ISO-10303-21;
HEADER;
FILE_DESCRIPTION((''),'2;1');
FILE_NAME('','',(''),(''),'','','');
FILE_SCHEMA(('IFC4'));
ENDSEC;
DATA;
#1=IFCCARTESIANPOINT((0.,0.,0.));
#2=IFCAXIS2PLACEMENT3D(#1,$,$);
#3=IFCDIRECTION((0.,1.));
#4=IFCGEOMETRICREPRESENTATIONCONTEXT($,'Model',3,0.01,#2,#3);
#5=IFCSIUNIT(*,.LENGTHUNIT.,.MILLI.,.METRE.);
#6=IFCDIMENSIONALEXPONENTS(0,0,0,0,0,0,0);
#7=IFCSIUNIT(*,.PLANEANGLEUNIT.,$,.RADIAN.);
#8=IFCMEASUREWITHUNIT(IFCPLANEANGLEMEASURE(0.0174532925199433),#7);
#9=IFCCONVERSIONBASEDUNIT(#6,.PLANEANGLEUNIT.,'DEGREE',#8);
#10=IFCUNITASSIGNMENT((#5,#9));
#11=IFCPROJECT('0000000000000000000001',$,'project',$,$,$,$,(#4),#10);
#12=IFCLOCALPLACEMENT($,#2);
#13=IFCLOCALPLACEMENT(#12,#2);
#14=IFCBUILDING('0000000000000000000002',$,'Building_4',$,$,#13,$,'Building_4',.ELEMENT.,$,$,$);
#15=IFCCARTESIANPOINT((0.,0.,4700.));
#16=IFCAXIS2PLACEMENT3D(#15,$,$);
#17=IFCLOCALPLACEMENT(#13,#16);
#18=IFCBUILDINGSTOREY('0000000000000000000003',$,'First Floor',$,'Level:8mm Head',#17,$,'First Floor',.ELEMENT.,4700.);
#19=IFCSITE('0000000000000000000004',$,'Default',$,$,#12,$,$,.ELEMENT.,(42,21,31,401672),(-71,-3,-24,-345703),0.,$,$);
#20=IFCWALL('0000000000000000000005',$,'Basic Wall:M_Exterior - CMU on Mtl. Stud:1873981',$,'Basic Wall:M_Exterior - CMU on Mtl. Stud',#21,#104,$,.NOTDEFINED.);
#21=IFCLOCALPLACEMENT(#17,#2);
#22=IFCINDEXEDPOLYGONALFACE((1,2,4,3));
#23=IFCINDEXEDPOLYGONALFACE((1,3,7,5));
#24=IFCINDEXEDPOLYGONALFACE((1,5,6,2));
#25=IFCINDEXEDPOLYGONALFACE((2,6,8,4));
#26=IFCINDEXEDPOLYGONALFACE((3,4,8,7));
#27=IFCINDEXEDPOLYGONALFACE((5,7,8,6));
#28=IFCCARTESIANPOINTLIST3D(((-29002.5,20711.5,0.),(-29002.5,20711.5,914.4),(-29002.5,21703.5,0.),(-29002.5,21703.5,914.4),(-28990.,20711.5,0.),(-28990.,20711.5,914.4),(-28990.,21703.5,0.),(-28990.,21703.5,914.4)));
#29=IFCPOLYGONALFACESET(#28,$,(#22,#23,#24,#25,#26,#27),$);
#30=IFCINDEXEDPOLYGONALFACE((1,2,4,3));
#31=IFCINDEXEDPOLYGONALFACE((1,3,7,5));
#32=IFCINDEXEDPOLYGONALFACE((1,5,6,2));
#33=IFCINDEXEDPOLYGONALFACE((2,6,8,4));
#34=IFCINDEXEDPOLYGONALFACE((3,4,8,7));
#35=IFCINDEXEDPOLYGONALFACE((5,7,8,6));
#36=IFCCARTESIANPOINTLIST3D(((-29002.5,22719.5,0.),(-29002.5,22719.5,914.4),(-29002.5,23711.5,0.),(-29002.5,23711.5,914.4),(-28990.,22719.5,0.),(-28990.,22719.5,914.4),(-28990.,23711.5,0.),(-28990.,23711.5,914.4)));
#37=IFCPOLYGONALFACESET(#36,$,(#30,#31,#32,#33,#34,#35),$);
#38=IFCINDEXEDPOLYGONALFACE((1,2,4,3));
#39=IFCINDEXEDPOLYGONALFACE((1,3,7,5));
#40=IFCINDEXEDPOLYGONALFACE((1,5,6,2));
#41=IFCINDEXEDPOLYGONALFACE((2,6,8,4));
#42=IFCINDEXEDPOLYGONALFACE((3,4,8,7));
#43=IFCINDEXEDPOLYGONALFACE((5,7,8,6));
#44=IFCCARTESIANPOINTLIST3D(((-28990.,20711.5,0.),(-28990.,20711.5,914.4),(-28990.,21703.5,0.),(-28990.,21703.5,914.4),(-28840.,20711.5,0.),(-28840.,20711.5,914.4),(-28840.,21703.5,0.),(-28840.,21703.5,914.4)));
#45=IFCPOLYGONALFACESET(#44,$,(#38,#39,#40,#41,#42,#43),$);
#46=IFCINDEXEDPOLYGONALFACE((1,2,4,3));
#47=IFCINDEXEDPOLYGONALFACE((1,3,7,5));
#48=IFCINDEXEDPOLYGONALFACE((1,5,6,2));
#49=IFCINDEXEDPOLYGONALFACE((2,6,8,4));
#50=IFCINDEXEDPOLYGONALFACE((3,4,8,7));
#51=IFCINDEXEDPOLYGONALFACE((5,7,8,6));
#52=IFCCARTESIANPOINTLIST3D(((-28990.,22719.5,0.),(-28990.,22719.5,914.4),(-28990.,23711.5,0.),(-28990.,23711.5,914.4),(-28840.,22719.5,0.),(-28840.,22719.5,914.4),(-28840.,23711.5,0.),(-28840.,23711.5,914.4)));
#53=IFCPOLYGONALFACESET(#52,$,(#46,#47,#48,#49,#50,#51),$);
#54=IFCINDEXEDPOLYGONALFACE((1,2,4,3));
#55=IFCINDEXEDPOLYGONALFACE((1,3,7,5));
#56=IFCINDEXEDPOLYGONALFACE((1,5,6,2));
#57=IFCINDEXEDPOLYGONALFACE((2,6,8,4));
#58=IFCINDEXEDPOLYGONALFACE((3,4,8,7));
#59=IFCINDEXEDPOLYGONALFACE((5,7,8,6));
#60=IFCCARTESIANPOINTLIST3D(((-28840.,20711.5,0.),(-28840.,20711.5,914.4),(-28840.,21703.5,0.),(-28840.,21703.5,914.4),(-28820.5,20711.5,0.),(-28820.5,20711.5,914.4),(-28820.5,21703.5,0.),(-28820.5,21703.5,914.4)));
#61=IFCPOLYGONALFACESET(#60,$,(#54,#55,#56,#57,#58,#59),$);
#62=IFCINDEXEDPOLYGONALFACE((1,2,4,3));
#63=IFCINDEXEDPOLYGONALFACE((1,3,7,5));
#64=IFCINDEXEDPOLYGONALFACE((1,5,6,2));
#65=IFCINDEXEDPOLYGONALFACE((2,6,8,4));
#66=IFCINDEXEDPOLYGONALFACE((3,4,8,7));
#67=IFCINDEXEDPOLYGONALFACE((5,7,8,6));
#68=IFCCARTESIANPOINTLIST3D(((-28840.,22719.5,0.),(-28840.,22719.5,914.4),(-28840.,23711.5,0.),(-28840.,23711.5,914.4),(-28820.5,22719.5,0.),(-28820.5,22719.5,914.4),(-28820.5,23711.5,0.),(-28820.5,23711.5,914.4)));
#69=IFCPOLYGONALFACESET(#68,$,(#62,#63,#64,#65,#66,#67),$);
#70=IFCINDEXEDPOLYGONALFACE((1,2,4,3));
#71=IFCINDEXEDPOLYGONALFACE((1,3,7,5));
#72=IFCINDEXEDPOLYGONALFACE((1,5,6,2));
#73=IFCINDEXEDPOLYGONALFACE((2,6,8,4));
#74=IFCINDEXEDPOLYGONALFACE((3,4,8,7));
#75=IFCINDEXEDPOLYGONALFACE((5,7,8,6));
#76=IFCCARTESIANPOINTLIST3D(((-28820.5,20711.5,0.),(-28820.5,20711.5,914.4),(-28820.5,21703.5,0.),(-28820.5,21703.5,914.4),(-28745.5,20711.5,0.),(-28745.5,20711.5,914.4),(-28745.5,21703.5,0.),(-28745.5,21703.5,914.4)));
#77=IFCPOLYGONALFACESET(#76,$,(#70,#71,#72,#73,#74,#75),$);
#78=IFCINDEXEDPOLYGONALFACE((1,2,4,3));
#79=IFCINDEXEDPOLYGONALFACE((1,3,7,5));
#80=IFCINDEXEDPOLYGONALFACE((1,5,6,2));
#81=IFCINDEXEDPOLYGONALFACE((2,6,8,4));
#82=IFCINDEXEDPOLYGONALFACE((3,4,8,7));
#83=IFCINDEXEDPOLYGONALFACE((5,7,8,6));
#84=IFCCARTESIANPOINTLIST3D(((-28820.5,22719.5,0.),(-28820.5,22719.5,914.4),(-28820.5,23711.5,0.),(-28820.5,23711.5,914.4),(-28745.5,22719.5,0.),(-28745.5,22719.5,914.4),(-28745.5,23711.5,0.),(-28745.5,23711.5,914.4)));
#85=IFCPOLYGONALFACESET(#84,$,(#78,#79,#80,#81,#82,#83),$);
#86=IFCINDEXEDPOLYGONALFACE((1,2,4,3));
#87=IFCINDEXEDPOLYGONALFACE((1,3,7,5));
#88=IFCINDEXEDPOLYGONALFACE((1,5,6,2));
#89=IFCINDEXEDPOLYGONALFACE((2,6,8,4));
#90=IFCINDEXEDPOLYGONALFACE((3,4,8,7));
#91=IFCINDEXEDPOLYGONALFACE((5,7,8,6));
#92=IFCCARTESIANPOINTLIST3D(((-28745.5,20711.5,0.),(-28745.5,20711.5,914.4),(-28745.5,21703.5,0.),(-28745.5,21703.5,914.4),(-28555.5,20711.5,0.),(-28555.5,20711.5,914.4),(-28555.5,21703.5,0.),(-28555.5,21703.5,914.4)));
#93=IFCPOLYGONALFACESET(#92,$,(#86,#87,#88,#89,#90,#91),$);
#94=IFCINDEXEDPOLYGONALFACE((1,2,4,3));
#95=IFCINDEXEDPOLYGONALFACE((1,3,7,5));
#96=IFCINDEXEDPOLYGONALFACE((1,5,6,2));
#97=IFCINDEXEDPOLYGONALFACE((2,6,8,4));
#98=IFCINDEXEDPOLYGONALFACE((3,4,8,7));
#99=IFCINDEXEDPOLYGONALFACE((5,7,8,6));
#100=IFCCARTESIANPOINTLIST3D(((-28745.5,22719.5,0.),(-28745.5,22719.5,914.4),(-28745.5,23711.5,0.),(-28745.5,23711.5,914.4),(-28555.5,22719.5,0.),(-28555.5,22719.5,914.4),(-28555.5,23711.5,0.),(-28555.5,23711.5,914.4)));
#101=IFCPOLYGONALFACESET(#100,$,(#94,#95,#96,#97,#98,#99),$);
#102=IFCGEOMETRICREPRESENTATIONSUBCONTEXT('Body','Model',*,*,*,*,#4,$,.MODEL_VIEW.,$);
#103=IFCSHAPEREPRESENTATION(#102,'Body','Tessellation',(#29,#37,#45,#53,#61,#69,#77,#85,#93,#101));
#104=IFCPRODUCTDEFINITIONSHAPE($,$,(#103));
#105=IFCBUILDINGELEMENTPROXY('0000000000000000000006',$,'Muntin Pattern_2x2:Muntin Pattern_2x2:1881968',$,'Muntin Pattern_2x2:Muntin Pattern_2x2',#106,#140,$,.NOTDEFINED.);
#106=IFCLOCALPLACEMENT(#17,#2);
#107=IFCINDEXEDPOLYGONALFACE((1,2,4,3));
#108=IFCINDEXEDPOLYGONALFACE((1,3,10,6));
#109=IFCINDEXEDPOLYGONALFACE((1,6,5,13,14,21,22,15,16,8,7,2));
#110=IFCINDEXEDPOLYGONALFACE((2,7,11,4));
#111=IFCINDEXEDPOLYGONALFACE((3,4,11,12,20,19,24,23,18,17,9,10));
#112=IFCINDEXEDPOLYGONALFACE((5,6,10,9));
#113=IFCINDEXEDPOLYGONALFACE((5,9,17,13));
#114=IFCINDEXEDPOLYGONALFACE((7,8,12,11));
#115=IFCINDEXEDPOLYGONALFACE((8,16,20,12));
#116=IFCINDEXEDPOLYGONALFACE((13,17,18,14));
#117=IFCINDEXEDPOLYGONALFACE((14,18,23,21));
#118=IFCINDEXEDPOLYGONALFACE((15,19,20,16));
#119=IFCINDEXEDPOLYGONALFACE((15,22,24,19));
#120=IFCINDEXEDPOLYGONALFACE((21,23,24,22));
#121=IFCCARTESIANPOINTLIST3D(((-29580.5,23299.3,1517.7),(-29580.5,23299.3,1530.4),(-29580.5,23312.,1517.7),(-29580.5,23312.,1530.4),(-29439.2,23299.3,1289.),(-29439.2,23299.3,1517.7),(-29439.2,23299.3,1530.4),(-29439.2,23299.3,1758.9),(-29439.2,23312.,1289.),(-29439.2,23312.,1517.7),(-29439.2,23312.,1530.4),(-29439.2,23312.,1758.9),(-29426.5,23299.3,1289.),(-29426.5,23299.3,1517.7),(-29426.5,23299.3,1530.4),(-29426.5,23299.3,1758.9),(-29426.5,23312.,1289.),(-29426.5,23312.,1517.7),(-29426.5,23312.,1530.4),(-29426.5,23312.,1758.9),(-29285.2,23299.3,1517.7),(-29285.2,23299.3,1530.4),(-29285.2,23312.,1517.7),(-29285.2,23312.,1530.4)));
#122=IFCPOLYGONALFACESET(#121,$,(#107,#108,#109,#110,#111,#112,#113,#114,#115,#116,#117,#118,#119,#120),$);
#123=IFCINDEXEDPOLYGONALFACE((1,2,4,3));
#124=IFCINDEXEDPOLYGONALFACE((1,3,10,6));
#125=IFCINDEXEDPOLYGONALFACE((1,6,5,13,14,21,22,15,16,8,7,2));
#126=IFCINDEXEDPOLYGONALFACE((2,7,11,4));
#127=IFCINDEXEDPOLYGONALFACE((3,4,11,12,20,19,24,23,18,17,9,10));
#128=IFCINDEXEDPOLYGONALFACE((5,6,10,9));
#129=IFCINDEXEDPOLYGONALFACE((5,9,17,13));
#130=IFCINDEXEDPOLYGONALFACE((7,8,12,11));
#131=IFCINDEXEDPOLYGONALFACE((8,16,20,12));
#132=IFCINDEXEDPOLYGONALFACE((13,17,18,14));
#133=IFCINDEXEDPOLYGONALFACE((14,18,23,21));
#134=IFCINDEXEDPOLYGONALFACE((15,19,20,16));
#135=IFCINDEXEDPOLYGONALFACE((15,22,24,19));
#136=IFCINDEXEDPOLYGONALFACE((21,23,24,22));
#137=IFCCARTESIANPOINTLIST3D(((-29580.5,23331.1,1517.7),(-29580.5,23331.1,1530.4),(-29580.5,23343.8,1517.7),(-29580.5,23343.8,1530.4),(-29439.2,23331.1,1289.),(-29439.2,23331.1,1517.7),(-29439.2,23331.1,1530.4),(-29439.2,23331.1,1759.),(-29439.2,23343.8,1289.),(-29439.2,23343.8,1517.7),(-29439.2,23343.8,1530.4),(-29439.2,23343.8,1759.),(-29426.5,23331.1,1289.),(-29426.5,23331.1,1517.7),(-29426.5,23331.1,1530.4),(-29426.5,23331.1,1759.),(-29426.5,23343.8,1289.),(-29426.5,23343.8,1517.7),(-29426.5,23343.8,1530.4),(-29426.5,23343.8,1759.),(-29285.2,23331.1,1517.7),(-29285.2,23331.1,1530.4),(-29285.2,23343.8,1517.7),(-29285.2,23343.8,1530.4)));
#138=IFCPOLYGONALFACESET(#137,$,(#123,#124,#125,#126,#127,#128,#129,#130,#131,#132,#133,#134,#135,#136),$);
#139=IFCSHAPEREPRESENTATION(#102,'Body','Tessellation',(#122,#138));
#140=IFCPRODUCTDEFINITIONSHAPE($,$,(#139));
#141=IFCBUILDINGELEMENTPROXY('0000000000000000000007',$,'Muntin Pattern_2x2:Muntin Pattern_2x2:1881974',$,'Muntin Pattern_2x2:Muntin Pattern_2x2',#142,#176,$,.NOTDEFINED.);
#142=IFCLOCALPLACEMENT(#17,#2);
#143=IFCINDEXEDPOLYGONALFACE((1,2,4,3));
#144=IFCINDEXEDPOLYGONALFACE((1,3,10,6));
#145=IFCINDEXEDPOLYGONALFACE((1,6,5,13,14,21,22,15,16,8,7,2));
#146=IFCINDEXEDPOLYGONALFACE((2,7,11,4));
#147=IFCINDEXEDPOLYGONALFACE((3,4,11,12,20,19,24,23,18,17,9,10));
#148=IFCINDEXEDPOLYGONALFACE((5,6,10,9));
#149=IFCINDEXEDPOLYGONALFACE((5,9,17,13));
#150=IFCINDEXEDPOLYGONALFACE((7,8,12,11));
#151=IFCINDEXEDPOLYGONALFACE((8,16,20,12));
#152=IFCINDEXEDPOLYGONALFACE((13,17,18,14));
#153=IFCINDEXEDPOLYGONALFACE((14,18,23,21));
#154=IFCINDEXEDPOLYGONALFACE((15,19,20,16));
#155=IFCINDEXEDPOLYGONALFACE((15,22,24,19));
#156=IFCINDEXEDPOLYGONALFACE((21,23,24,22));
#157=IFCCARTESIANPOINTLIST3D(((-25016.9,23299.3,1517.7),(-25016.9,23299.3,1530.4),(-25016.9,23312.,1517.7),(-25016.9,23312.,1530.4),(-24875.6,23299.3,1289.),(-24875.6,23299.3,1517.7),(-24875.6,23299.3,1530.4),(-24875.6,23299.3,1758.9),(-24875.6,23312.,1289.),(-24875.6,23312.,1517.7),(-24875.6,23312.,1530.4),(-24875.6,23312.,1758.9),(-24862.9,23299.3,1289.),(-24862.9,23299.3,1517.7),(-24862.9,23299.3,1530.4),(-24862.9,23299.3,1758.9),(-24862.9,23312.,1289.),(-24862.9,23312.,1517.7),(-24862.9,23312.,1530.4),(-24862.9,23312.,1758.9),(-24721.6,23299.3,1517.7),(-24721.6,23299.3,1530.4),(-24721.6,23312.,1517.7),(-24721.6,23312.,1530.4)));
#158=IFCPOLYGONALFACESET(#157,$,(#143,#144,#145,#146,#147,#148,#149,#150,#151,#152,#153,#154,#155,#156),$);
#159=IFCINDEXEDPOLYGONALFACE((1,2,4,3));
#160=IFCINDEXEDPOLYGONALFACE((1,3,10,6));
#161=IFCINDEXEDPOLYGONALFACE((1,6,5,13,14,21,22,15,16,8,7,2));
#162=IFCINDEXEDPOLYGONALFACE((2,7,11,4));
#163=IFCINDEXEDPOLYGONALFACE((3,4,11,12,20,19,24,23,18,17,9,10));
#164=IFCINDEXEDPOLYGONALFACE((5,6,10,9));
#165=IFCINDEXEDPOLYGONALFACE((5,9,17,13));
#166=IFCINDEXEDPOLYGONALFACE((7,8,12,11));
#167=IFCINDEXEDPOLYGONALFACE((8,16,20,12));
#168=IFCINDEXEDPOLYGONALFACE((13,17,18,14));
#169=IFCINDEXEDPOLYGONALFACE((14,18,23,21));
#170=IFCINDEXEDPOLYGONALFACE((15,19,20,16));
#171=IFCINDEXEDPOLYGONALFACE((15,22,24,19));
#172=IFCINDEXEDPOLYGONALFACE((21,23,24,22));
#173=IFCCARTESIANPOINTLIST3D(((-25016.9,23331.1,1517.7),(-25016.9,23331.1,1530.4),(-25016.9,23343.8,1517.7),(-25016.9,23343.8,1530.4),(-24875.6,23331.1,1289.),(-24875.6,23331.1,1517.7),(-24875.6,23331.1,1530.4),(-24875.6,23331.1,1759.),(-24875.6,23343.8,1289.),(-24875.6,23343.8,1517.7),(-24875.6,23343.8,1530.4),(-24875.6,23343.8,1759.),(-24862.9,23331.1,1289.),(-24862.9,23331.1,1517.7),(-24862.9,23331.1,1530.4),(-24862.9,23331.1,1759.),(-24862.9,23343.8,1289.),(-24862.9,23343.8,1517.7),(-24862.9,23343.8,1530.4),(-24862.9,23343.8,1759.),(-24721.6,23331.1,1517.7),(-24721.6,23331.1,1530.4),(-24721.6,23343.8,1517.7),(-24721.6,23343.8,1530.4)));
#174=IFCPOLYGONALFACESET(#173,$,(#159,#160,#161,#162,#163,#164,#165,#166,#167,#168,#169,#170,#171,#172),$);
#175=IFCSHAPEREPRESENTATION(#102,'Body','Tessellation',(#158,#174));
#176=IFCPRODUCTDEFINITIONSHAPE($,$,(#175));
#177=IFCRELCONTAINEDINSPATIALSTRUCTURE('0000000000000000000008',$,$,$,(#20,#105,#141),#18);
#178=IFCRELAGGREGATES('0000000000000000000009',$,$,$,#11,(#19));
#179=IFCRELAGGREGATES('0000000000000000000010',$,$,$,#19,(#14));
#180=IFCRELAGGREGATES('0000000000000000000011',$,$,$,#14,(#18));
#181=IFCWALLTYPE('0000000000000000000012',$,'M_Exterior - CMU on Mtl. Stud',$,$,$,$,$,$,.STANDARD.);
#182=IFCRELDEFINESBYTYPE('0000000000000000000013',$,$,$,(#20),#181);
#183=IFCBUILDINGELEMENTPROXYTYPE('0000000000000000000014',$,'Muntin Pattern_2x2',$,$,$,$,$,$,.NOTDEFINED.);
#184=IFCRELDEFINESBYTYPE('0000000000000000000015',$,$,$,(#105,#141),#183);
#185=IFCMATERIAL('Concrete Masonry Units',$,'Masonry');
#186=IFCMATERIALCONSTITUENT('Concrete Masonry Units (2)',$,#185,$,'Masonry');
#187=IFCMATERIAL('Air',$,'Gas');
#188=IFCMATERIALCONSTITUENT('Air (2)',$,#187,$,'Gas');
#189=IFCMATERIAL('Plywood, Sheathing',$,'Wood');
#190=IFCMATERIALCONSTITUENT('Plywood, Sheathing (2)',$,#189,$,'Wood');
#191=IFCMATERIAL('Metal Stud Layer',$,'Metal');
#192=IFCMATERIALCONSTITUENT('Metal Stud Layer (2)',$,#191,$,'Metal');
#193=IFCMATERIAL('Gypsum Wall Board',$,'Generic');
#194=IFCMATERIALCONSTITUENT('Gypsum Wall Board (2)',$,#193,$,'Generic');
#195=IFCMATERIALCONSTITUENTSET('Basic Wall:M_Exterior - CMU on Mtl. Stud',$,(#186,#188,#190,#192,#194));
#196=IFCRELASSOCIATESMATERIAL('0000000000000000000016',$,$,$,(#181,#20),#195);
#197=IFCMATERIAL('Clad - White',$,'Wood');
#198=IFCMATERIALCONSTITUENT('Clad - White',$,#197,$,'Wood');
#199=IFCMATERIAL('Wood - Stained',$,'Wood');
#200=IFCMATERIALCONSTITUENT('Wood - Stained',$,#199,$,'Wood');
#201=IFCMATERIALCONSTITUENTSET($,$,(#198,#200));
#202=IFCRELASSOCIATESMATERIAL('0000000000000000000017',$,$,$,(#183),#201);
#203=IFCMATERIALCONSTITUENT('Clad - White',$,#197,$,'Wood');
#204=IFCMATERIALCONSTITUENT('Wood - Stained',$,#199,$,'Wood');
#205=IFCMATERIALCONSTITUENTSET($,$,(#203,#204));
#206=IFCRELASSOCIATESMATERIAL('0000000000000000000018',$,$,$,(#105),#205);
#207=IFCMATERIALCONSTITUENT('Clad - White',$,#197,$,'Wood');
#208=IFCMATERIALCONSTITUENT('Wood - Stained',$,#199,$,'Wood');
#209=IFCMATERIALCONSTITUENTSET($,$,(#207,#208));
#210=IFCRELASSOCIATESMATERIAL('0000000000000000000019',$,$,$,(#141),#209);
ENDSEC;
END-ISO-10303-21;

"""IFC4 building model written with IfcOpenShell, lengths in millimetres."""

from ifc_helpers import new_model, entity, si_unit, converted_unit, direction, frame, origin, place, context, subcontext, project, spatial, indexed_curve, outline, extrude, source, transform, mapped, material, constituent, constituent_set, type_object, type_shapes, element, save


model = new_model("IFC4")

# Units and contexts
model_context = context("Model", 3, precision=0.01, world=origin(), true_north=direction((0.0, 1.0)))
body_context = subcontext(model_context, "Body", "Model", "MODEL_VIEW")
ifc_project = project(units=[si_unit("LENGTHUNIT", "METRE", prefix="MILLI"), converted_unit("PLANEANGLEUNIT", "DEGREE", entity("IfcPlaneAngleMeasure", 0.0174532925199433), si_unit("PLANEANGLEUNIT", "RADIAN"), dimensions=[0, 0, 0, 0, 0, 0, 0])], contexts=[model_context])

# Site, building, storey
site_placement = place(None, origin())
site = spatial("IfcSite", under=ifc_project, at=site_placement, Name="Default", CompositionType="ELEMENT", RefLatitude=(42, 21, 31, 401672), RefLongitude=(-71, -3, -24, -345703), RefElevation=0.0)
building_placement = place(site_placement, origin())
building = spatial("IfcBuilding", under=site, at=building_placement, Name="Building_4", LongName="Building_4", CompositionType="ELEMENT")
storey_placement = place(building_placement, frame((0.0, 0.0, 4700.0)))
storey = spatial("IfcBuildingStorey", under=building, at=storey_placement, Name="First Floor", ObjectType="Level:8mm Head", LongName="First Floor", CompositionType="ELEMENT", Elevation=4700.0)

# Shared definitions
ifc_material_1 = material(Name="Air", Category="Gas")
ifc_material_2 = material(Name="Plywood, Sheathing", Category="Wood")
ifc_material_3 = material(Name="Metal Stud Layer", Category="Metal")
ifc_material_4 = material(Name="Gypsum Wall Board", Category="Generic")

# Wall, opening
ifc_material_5 = material(Name="Concrete Masonry Units", Category="Masonry")
ifc_constituent_1 = constituent(ifc_material_5, Name="Concrete Masonry Units (2)", Category="Masonry")
ifc_constituent_2 = constituent(ifc_material_1, Name="Air (2)", Category="Gas")
ifc_constituent_3 = constituent(ifc_material_2, Name="Plywood, Sheathing (2)", Category="Wood")
ifc_constituent_4 = constituent(ifc_material_3, Name="Metal Stud Layer (2)", Category="Metal")
ifc_constituent_5 = constituent(ifc_material_4, Name="Gypsum Wall Board (2)", Category="Generic")
ifc_constituent_set_1 = constituent_set(constituents=[ifc_constituent_1, ifc_constituent_2, ifc_constituent_3, ifc_constituent_4, ifc_constituent_5], Name="Basic Wall:M_Exterior - CMU on Mtl. Stud")
wall_type_1 = type_object("IfcWallType", Name="M_Exterior - CMU on Mtl. Stud", PredefinedType="STANDARD", material=ifc_constituent_set_1)
wall_1_placement = place(storey_placement, frame((-28779.0, 23711.5, 0.0), z_axis=(0.0, 0.0, 1.0), x_axis=(0.0, -1.0, 0.0)))
wall_1 = element("IfcWall", 1, at=wall_1_placement, inside=storey, type_object=wall_type_1, material=ifc_constituent_set_1, Name="Basic Wall:M_Exterior - CMU on Mtl. Stud:1873981", ObjectType="Basic Wall:M_Exterior - CMU on Mtl. Stud", PredefinedType="NOTDEFINED", context=body_context, shape_type="SweptSolid", body=[
    extrude(outline(indexed_curve([(-6.2, -496.0), (6.2, -496.0), (6.2, 496.0), (-6.2, 496.0), (-6.2, -496.0)], self_intersect=False)), frame((2504.0, -217.2, 0.0), z_axis=(0.0, 0.0, 1.0), x_axis=(0.0, 1.0, 0.0)), (0.0, 0.0, 1.0), 914.4),
    extrude(outline(indexed_curve([(-6.2, -496.0), (6.2, -496.0), (6.2, 496.0), (-6.2, 496.0), (-6.2, -496.0)], self_intersect=False)), frame((496.0, -217.2, 0.0), z_axis=(0.0, 0.0, 1.0), x_axis=(0.0, 1.0, 0.0)), (0.0, 0.0, 1.0), 914.4),
    extrude(outline(indexed_curve([(-496.0, -75.0), (496.0, -75.0), (496.0, 75.0), (-496.0, 75.0), (-496.0, -75.0)], self_intersect=False)), frame((2504.0, -136.0, 0.0)), (0.0, 0.0, 1.0), 914.4),
    extrude(outline(indexed_curve([(-496.0, -75.0), (496.0, -75.0), (496.0, 75.0), (-496.0, 75.0), (-496.0, -75.0)], self_intersect=False)), frame((496.0, -136.0, 0.0)), (0.0, 0.0, 1.0), 914.4),
    extrude(outline(indexed_curve([(-496.0, -9.7), (496.0, -9.7), (496.0, 9.8), (-496.0, 9.8), (-496.0, -9.7)], self_intersect=False)), frame((2504.0, -51.3, 0.0)), (0.0, 0.0, 1.0), 914.4),
    extrude(outline(indexed_curve([(-496.0, -9.7), (496.0, -9.7), (496.0, 9.8), (-496.0, 9.8), (-496.0, -9.7)], self_intersect=False)), frame((496.0, -51.3, 0.0)), (0.0, 0.0, 1.0), 914.4),
    extrude(outline(indexed_curve([(-496.0, -37.5), (496.0, -37.5), (496.0, 37.5), (-496.0, 37.5), (-496.0, -37.5)], self_intersect=False)), frame((2504.0, -4.0, 0.0)), (0.0, 0.0, 1.0), 914.4),
    extrude(outline(indexed_curve([(-496.0, -37.5), (496.0, -37.5), (496.0, 37.5), (-496.0, 37.5), (-496.0, -37.5)], self_intersect=False)), frame((496.0, -4.0, 0.0)), (0.0, 0.0, 1.0), 914.4),
    extrude(outline(indexed_curve([(-95.0, -496.0), (95.0, -496.0), (95.0, 496.0), (-95.0, 496.0), (-95.0, -496.0)], self_intersect=False)), frame((2504.0, 128.5, 0.0), z_axis=(0.0, 0.0, 1.0), x_axis=(0.0, -1.0, 0.0)), (0.0, 0.0, 1.0), 914.4),
    extrude(outline(indexed_curve([(-95.0, -496.0), (95.0, -496.0), (95.0, 496.0), (-95.0, 496.0), (-95.0, -496.0)], self_intersect=False)), frame((496.0, 128.5, 0.0), z_axis=(0.0, 0.0, 1.0), x_axis=(0.0, -1.0, 0.0)), (0.0, 0.0, 1.0), 914.4),
])
opening_1_placement = place(wall_1_placement, origin())
element("IfcOpeningElement", 2, at=opening_1_placement, cuts=wall_1, PredefinedType="OPENING", context=body_context, shape_type="SweptSolid", body=[
    extrude(outline(indexed_curve([(-508.0, -1117.6), (508.0, -1117.6), (508.0, 1117.6), (-508.0, 1117.6), (-508.0, -1117.6)], self_intersect=False)), frame((1500.0, -1747.5, 1117.6), z_axis=(0.0, 1.0, 0.0), x_axis=(-1.0, 0.0, 0.0)), (0.0, 0.0, 1.0), 3048.0),
])

# Building element proxies
ifc_material_6 = material(Name="Clad - White", Category="Wood")
ifc_constituent_6 = constituent(ifc_material_6, Name="Clad - White", Category="Wood")
ifc_material_7 = material(Name="Wood - Stained", Category="Wood")
ifc_constituent_7 = constituent(ifc_material_7, Name="Wood - Stained", Category="Wood")
ifc_constituent_set_2 = constituent_set(constituents=[ifc_constituent_6, ifc_constituent_7])
ifc_constituent_8 = constituent(ifc_material_6, Name="Clad - White", Category="Wood")
ifc_constituent_9 = constituent(ifc_material_7, Name="Wood - Stained", Category="Wood")
ifc_constituent_set_3 = constituent_set(constituents=[ifc_constituent_8, ifc_constituent_9])
building_element_proxy_type_1 = type_object("IfcBuildingElementProxyType", Name="Muntin Pattern_2x2", PredefinedType="NOTDEFINED", material=ifc_constituent_set_3)
shared_shape_1 = source(origin(), body_context, "Body", "SweptSolid", [
    extrude(outline(indexed_curve([(6.4, -6.4), (234.9, -6.4), (234.9, 6.3), (6.4, 6.3), (6.4, 147.6), (-6.3, 147.6), (-6.3, 6.3), (-235.0, 6.3), (-235.0, -6.4), (-6.3, -6.4), (-6.3, -147.6), (6.4, -147.6), (6.4, -6.4)], self_intersect=False)), frame((0.0, 9.5, 235.0), z_axis=(0.0, 1.0, 0.0), x_axis=(0.0, 0.0, 1.0)), (0.0, 0.0, 1.0), 12.7),
    extrude(outline(indexed_curve([(6.4, -6.4), (235.0, -6.4), (235.0, 6.3), (6.4, 6.3), (6.4, 147.6), (-6.3, 147.6), (-6.3, 6.3), (-235.0, 6.3), (-235.0, -6.4), (-6.3, -6.4), (-6.3, -147.6), (6.4, -147.6), (6.4, -6.4)], self_intersect=False)), frame((0.0, -22.2, 235.0), z_axis=(0.0, 1.0, 0.0), x_axis=(0.0, 0.0, 1.0)), (0.0, 0.0, 1.0), 12.7),
])
type_shapes(building_element_proxy_type_1, [shared_shape_1])
proxy_1_placement = place(storey_placement, frame((-29432.9, 23321.5, 1289.0), z_axis=(0.0, 0.0, 1.0), x_axis=(-1.0, 0.0, 0.0)))
element("IfcBuildingElementProxy", 3, at=proxy_1_placement, inside=storey, type_object=building_element_proxy_type_1, material=ifc_constituent_set_2, Name="Muntin Pattern_2x2:Muntin Pattern_2x2:1881968", ObjectType="Muntin Pattern_2x2:Muntin Pattern_2x2", PredefinedType="NOTDEFINED", context=body_context, shape_type="MappedRepresentation", body=[
    mapped(shared_shape_1, transform((0.0, 0.0, 0.0), scale=1.0)),
])
ifc_constituent_10 = constituent(ifc_material_6, Name="Clad - White", Category="Wood")
ifc_constituent_11 = constituent(ifc_material_7, Name="Wood - Stained", Category="Wood")
ifc_constituent_set_4 = constituent_set(constituents=[ifc_constituent_10, ifc_constituent_11])
proxy_2_placement = place(storey_placement, frame((-24869.3, 23321.5, 1289.0), z_axis=(0.0, 0.0, 1.0), x_axis=(-1.0, 0.0, 0.0)))
element("IfcBuildingElementProxy", 4, at=proxy_2_placement, inside=storey, type_object=building_element_proxy_type_1, material=ifc_constituent_set_4, Name="Muntin Pattern_2x2:Muntin Pattern_2x2:1881974", ObjectType="Muntin Pattern_2x2:Muntin Pattern_2x2", PredefinedType="NOTDEFINED", context=body_context, shape_type="MappedRepresentation", body=[
    mapped(shared_shape_1, transform((0.0, 0.0, 0.0), scale=1.0)),
])

save(model, "model.ifc")
